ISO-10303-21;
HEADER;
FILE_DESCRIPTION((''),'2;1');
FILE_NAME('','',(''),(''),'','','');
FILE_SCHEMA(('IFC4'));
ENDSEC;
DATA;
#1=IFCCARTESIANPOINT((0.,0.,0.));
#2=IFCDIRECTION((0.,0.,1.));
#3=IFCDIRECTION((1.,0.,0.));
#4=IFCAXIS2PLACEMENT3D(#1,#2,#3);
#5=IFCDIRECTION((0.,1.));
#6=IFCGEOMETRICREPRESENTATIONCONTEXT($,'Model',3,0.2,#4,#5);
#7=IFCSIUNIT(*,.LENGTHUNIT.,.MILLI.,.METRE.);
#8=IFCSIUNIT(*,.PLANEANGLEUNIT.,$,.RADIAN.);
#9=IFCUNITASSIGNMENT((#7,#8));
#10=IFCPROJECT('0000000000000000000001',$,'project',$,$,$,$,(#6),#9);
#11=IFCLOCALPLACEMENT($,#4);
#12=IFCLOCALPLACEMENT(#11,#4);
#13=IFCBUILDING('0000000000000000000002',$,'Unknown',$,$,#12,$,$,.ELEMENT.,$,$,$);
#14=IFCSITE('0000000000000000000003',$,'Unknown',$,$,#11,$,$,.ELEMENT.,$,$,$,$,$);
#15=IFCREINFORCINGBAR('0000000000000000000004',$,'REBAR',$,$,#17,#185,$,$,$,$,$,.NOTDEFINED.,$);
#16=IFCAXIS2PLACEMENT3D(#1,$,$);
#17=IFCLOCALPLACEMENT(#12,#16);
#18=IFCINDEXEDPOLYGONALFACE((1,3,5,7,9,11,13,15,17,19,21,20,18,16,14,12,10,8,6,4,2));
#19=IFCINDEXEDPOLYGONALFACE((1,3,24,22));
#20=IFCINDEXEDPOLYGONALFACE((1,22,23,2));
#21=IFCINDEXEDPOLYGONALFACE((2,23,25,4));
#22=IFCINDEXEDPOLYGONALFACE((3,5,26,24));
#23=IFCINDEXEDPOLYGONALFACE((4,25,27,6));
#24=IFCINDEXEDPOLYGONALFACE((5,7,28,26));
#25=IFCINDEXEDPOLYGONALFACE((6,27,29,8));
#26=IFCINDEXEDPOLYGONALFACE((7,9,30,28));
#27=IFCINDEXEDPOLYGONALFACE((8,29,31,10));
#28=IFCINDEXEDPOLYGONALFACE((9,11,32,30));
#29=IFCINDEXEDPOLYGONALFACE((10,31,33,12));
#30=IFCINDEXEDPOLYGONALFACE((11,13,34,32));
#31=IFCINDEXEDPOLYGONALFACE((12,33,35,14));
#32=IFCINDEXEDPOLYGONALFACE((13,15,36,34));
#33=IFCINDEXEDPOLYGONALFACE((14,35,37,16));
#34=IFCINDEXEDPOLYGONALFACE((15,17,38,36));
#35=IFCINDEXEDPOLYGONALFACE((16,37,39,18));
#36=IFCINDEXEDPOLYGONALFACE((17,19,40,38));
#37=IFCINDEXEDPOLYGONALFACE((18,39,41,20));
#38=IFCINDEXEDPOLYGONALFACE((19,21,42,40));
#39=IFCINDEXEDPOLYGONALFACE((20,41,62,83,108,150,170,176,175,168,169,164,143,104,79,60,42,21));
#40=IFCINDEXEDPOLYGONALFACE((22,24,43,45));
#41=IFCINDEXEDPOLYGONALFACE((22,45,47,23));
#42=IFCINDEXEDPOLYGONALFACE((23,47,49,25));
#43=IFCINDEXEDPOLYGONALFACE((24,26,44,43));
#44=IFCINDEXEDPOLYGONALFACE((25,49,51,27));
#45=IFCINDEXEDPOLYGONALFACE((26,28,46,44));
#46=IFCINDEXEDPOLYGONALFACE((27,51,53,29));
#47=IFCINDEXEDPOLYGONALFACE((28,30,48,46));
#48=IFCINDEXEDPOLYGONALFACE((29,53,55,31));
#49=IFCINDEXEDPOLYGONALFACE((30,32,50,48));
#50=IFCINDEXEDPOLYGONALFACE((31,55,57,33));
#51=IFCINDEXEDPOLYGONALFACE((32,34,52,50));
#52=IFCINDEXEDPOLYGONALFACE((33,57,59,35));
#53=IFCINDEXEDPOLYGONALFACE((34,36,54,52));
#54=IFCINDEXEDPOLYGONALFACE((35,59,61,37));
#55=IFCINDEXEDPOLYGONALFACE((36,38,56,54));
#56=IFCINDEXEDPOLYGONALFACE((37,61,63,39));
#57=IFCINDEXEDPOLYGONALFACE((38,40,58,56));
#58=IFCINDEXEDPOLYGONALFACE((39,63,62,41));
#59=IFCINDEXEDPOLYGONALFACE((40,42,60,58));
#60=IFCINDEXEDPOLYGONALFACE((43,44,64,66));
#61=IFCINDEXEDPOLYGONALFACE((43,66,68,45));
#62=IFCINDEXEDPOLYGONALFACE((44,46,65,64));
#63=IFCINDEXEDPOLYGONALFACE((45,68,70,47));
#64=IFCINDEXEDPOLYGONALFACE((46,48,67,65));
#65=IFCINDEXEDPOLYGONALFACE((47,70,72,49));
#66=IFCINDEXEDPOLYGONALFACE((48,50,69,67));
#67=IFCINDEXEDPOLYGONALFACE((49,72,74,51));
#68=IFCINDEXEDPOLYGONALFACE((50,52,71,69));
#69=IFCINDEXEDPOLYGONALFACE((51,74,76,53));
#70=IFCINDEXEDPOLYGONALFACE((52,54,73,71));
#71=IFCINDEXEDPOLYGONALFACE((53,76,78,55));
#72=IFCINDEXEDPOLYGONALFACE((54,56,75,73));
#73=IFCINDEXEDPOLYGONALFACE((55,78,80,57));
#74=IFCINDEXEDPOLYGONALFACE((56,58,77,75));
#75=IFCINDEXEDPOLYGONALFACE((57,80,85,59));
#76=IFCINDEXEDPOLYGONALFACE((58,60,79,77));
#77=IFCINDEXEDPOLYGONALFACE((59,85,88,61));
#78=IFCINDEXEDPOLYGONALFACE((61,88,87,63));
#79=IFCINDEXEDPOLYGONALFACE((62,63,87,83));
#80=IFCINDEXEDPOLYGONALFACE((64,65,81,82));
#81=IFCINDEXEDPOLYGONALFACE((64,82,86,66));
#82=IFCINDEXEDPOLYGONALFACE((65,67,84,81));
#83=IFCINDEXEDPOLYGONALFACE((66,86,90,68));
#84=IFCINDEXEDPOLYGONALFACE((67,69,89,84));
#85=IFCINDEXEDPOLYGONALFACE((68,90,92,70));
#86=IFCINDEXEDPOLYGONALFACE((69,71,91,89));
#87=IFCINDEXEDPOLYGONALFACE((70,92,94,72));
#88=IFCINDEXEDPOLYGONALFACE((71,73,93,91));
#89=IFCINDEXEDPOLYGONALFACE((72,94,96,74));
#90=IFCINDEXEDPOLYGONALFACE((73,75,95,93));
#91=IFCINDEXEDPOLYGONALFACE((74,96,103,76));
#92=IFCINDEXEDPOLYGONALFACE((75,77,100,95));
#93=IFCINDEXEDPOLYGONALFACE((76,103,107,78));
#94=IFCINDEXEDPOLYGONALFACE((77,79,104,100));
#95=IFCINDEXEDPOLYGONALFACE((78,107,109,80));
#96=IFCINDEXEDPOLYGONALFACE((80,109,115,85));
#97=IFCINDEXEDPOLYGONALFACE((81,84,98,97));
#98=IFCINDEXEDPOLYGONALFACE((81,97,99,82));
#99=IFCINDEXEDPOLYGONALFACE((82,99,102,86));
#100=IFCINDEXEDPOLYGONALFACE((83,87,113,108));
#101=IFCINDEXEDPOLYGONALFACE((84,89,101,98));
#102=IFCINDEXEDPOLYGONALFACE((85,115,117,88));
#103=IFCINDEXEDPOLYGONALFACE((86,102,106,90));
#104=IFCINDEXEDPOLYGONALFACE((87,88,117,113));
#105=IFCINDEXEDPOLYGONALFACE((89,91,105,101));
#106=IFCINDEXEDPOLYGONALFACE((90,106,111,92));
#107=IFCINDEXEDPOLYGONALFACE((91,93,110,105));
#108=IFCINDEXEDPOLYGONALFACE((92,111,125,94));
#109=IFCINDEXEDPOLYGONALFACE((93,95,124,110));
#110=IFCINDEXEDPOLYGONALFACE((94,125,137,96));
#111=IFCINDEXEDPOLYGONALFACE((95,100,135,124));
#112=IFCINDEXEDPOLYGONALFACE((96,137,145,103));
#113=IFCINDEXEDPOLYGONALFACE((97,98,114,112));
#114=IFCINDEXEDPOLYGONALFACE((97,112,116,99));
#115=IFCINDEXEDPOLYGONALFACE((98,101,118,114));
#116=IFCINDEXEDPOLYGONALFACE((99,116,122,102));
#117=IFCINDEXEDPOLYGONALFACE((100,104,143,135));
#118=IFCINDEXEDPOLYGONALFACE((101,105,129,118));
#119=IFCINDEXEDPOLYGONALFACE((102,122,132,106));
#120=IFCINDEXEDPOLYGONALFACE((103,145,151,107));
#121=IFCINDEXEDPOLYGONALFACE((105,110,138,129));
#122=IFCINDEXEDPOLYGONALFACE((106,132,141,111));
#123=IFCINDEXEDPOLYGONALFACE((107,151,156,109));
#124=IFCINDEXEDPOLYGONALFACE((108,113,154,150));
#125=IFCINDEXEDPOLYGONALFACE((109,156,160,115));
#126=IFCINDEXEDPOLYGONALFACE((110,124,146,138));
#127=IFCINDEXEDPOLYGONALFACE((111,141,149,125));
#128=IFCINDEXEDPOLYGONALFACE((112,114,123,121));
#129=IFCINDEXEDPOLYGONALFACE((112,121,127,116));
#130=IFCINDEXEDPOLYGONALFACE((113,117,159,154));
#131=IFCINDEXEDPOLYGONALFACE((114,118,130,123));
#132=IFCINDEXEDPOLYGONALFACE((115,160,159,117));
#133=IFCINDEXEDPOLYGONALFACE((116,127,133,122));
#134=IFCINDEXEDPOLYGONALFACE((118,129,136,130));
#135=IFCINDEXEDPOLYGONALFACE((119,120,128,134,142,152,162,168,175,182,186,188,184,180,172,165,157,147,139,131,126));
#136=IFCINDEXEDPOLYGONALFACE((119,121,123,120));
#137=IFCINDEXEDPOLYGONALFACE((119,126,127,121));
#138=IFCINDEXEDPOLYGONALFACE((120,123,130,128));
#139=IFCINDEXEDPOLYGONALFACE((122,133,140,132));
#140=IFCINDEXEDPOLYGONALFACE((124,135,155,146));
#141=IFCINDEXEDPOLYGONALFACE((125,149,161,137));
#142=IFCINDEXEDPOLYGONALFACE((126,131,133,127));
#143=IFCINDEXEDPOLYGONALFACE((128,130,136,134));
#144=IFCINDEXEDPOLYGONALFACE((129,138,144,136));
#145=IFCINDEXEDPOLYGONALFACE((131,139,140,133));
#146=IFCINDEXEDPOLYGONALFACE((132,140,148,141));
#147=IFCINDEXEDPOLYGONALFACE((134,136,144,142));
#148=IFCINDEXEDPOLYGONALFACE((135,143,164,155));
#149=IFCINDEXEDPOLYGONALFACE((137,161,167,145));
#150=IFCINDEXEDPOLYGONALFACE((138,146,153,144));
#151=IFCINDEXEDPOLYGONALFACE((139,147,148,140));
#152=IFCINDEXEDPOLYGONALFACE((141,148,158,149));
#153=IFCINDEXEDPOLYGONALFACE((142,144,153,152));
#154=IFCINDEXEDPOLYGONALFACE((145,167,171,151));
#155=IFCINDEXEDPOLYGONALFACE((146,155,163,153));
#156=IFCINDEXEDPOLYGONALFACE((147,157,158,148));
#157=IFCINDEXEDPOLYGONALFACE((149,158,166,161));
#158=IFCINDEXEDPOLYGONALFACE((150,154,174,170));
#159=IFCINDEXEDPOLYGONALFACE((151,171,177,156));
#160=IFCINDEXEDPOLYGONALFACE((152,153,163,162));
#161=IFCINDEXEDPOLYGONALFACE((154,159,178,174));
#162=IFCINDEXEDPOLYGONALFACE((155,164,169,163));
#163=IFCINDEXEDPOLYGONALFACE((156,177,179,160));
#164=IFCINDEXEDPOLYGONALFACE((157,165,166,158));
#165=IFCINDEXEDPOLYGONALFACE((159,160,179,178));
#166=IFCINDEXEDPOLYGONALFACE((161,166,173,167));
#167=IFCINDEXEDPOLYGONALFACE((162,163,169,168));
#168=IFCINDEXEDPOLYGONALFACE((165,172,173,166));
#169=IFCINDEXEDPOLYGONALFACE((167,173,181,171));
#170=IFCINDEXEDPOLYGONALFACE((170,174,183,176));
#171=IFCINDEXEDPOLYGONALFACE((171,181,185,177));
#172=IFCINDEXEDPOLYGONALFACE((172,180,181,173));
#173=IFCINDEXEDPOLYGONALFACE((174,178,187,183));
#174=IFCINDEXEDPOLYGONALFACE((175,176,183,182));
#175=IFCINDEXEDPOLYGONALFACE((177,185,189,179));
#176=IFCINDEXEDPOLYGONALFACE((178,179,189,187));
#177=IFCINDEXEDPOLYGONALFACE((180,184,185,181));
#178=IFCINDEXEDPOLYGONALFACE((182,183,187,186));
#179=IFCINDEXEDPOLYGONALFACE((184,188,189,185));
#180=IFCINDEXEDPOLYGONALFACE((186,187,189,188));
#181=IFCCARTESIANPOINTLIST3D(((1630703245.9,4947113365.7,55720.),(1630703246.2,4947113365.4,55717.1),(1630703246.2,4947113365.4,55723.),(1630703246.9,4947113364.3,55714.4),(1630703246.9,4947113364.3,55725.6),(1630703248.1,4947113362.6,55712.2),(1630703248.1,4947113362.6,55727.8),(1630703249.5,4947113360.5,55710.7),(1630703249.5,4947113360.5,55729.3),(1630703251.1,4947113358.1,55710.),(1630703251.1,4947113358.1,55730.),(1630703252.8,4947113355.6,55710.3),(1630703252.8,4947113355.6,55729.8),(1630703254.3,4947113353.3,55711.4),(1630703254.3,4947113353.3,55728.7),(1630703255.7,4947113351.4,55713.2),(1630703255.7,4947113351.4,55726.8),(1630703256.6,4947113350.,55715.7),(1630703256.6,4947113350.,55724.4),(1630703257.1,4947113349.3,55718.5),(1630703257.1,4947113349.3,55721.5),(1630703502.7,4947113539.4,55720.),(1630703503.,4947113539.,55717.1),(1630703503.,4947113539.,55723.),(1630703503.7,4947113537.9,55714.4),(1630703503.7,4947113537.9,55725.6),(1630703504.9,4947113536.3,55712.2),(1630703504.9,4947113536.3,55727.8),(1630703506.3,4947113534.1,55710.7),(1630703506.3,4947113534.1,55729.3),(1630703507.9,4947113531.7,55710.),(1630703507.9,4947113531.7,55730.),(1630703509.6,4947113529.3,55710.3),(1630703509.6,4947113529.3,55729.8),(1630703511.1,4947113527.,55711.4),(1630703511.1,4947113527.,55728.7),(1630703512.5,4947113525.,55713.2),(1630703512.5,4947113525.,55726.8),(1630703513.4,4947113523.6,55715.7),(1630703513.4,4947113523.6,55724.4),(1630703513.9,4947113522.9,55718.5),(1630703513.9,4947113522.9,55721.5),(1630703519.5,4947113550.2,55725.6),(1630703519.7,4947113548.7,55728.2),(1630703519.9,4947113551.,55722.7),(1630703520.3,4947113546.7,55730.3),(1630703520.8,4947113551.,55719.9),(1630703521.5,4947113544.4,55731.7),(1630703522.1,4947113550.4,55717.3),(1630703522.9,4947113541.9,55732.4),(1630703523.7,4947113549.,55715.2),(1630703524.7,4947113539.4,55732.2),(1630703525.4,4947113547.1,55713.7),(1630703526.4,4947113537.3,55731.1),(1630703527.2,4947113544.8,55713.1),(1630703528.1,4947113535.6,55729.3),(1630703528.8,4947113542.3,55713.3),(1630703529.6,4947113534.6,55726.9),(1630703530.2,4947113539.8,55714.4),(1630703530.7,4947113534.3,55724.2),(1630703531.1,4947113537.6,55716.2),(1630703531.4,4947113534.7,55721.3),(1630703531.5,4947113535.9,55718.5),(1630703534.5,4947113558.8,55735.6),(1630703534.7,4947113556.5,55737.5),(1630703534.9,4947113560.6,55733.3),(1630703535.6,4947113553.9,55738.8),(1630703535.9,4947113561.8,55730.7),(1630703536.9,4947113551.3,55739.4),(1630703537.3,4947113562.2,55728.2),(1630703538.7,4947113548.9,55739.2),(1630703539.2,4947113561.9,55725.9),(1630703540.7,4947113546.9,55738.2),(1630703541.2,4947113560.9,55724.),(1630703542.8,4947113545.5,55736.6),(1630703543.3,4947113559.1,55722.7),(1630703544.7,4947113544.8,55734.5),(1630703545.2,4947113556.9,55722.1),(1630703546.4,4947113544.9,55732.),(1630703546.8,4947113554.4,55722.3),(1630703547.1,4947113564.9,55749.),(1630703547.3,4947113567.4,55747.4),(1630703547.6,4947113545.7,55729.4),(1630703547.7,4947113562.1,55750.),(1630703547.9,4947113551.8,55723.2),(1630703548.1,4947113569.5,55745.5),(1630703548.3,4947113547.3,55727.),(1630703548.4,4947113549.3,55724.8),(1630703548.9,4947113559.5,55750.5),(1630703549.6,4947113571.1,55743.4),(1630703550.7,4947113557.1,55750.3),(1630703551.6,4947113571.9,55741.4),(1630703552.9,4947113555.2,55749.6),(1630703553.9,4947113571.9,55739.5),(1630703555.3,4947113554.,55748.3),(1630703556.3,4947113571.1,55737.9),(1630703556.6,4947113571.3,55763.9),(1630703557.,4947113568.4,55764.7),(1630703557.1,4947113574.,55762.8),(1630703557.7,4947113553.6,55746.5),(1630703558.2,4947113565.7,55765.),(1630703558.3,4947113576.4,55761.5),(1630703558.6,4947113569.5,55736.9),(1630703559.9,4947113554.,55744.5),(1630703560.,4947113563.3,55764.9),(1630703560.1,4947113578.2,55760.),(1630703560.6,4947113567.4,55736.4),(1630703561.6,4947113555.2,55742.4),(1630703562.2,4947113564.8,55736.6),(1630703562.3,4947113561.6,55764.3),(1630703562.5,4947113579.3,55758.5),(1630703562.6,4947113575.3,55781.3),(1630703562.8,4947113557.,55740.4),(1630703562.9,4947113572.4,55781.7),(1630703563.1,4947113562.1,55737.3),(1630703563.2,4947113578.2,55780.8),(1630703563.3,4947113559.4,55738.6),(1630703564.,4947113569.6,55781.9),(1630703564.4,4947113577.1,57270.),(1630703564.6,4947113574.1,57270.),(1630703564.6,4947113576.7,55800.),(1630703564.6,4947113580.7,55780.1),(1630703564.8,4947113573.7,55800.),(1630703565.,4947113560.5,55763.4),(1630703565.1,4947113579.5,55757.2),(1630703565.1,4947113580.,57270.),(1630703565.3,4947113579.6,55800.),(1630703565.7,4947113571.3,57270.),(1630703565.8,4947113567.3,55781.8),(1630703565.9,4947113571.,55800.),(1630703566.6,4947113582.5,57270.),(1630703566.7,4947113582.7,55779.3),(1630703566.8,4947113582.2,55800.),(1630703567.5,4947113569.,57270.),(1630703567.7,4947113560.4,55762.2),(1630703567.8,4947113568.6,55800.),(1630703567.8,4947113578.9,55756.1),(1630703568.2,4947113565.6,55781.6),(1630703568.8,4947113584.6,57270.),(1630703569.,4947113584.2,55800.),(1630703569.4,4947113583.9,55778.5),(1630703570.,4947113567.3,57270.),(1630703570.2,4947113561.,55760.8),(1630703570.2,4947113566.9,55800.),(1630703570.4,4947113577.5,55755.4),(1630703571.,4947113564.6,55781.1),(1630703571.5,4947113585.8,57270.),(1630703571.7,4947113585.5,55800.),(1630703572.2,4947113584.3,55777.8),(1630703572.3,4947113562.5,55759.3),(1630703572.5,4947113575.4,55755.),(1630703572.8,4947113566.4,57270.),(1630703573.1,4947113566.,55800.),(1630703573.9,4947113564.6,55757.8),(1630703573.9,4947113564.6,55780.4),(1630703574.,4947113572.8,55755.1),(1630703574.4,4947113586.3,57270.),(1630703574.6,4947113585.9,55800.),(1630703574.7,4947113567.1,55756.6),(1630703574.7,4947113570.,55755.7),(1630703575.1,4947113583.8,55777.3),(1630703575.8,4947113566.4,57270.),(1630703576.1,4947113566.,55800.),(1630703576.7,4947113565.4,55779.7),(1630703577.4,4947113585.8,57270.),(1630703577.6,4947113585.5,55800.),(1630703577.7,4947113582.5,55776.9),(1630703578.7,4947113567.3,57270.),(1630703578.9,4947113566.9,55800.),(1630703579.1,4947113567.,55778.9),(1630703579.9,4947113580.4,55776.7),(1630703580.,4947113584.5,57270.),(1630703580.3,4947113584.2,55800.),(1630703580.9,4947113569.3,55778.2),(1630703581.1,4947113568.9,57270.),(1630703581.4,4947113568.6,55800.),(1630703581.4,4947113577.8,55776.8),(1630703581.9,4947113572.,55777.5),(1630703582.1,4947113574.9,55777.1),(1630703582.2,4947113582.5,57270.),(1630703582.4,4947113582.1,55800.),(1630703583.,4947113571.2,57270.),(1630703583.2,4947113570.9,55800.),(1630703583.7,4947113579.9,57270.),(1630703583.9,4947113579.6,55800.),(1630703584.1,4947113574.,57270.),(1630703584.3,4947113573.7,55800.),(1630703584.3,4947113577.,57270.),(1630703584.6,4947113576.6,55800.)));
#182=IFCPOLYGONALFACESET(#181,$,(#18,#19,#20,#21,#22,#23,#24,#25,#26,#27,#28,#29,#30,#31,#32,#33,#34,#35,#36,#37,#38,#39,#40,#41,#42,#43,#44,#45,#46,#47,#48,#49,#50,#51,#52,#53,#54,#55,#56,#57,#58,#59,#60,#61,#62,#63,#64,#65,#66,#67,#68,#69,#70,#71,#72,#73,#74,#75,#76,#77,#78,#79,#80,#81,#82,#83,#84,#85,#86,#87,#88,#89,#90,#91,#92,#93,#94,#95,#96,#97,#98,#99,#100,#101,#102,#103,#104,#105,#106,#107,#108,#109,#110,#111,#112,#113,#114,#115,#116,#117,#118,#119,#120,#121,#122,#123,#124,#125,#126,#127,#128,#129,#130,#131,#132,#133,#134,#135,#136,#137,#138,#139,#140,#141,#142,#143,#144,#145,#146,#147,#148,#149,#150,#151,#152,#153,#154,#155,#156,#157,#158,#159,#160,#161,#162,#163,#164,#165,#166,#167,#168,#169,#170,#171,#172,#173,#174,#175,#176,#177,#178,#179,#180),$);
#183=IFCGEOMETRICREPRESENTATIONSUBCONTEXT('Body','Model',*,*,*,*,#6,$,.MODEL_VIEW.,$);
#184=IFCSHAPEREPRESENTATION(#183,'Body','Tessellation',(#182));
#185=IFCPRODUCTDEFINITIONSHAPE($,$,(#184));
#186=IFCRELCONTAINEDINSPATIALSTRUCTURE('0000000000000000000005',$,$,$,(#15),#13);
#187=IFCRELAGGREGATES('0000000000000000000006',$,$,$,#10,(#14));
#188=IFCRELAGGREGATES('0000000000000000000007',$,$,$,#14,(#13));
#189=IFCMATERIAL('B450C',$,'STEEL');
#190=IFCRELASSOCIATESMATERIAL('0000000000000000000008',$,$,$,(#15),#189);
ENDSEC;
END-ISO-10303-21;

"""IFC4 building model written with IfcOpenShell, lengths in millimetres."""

from ifc_helpers import new_model, entity, si_unit, direction, frame, origin_with_axes, place, context, subcontext, project, spatial, material, element, save


model = new_model("IFC4")

# Units and contexts
model_context = context("Model", 3, precision=0.2, world=origin_with_axes(), true_north=direction((0.0, 1.0)))
body_context = subcontext(model_context, "Body", "Model", "MODEL_VIEW")
ifc_project = project(units=[si_unit("LENGTHUNIT", "METRE", prefix="MILLI"), si_unit("PLANEANGLEUNIT", "RADIAN")], contexts=[model_context])

# Site, building
site_placement = place(None, origin_with_axes())
site = spatial("IfcSite", under=ifc_project, at=site_placement, Name="Unknown", CompositionType="ELEMENT")
building_placement = place(site_placement, origin_with_axes())
building = spatial("IfcBuilding", under=site, at=building_placement, Name="Unknown", CompositionType="ELEMENT")

# Reinforcing bar
ifc_material = material(Name="B450C", Category="STEEL")
reinforcing_bar_1_placement = place(building_placement, frame((1630703588.0, 4947113645.3, 55670.0), z_axis=(0.560162, -0.828383, 0.0), x_axis=(0.0, 0.0, 1.0)))
element("IfcReinforcingBar", 1, at=reinforcing_bar_1_placement, inside=building, material=ifc_material, Name="REBAR", PredefinedType="NOTDEFINED", context=body_context, shape_type="AdvancedSweptSolid", body=[
    entity("IfcSweptDiskSolid", entity("IfcIndexedPolyCurve", entity("IfcCartesianPointList3D", [[50.0, 440.0, 50.0], [50.0, 130.0, 50.0], [73.4, 73.4, 50.0], [130.0, 50.0, 50.0], [1600.0, 50.0, 49.5]]), [entity("IfcLineIndex", [1, 2]), entity("IfcArcIndex", [2, 3, 4]), entity("IfcLineIndex", [4, 5])]), 10.0),
])

save(model, "model.ifc")
